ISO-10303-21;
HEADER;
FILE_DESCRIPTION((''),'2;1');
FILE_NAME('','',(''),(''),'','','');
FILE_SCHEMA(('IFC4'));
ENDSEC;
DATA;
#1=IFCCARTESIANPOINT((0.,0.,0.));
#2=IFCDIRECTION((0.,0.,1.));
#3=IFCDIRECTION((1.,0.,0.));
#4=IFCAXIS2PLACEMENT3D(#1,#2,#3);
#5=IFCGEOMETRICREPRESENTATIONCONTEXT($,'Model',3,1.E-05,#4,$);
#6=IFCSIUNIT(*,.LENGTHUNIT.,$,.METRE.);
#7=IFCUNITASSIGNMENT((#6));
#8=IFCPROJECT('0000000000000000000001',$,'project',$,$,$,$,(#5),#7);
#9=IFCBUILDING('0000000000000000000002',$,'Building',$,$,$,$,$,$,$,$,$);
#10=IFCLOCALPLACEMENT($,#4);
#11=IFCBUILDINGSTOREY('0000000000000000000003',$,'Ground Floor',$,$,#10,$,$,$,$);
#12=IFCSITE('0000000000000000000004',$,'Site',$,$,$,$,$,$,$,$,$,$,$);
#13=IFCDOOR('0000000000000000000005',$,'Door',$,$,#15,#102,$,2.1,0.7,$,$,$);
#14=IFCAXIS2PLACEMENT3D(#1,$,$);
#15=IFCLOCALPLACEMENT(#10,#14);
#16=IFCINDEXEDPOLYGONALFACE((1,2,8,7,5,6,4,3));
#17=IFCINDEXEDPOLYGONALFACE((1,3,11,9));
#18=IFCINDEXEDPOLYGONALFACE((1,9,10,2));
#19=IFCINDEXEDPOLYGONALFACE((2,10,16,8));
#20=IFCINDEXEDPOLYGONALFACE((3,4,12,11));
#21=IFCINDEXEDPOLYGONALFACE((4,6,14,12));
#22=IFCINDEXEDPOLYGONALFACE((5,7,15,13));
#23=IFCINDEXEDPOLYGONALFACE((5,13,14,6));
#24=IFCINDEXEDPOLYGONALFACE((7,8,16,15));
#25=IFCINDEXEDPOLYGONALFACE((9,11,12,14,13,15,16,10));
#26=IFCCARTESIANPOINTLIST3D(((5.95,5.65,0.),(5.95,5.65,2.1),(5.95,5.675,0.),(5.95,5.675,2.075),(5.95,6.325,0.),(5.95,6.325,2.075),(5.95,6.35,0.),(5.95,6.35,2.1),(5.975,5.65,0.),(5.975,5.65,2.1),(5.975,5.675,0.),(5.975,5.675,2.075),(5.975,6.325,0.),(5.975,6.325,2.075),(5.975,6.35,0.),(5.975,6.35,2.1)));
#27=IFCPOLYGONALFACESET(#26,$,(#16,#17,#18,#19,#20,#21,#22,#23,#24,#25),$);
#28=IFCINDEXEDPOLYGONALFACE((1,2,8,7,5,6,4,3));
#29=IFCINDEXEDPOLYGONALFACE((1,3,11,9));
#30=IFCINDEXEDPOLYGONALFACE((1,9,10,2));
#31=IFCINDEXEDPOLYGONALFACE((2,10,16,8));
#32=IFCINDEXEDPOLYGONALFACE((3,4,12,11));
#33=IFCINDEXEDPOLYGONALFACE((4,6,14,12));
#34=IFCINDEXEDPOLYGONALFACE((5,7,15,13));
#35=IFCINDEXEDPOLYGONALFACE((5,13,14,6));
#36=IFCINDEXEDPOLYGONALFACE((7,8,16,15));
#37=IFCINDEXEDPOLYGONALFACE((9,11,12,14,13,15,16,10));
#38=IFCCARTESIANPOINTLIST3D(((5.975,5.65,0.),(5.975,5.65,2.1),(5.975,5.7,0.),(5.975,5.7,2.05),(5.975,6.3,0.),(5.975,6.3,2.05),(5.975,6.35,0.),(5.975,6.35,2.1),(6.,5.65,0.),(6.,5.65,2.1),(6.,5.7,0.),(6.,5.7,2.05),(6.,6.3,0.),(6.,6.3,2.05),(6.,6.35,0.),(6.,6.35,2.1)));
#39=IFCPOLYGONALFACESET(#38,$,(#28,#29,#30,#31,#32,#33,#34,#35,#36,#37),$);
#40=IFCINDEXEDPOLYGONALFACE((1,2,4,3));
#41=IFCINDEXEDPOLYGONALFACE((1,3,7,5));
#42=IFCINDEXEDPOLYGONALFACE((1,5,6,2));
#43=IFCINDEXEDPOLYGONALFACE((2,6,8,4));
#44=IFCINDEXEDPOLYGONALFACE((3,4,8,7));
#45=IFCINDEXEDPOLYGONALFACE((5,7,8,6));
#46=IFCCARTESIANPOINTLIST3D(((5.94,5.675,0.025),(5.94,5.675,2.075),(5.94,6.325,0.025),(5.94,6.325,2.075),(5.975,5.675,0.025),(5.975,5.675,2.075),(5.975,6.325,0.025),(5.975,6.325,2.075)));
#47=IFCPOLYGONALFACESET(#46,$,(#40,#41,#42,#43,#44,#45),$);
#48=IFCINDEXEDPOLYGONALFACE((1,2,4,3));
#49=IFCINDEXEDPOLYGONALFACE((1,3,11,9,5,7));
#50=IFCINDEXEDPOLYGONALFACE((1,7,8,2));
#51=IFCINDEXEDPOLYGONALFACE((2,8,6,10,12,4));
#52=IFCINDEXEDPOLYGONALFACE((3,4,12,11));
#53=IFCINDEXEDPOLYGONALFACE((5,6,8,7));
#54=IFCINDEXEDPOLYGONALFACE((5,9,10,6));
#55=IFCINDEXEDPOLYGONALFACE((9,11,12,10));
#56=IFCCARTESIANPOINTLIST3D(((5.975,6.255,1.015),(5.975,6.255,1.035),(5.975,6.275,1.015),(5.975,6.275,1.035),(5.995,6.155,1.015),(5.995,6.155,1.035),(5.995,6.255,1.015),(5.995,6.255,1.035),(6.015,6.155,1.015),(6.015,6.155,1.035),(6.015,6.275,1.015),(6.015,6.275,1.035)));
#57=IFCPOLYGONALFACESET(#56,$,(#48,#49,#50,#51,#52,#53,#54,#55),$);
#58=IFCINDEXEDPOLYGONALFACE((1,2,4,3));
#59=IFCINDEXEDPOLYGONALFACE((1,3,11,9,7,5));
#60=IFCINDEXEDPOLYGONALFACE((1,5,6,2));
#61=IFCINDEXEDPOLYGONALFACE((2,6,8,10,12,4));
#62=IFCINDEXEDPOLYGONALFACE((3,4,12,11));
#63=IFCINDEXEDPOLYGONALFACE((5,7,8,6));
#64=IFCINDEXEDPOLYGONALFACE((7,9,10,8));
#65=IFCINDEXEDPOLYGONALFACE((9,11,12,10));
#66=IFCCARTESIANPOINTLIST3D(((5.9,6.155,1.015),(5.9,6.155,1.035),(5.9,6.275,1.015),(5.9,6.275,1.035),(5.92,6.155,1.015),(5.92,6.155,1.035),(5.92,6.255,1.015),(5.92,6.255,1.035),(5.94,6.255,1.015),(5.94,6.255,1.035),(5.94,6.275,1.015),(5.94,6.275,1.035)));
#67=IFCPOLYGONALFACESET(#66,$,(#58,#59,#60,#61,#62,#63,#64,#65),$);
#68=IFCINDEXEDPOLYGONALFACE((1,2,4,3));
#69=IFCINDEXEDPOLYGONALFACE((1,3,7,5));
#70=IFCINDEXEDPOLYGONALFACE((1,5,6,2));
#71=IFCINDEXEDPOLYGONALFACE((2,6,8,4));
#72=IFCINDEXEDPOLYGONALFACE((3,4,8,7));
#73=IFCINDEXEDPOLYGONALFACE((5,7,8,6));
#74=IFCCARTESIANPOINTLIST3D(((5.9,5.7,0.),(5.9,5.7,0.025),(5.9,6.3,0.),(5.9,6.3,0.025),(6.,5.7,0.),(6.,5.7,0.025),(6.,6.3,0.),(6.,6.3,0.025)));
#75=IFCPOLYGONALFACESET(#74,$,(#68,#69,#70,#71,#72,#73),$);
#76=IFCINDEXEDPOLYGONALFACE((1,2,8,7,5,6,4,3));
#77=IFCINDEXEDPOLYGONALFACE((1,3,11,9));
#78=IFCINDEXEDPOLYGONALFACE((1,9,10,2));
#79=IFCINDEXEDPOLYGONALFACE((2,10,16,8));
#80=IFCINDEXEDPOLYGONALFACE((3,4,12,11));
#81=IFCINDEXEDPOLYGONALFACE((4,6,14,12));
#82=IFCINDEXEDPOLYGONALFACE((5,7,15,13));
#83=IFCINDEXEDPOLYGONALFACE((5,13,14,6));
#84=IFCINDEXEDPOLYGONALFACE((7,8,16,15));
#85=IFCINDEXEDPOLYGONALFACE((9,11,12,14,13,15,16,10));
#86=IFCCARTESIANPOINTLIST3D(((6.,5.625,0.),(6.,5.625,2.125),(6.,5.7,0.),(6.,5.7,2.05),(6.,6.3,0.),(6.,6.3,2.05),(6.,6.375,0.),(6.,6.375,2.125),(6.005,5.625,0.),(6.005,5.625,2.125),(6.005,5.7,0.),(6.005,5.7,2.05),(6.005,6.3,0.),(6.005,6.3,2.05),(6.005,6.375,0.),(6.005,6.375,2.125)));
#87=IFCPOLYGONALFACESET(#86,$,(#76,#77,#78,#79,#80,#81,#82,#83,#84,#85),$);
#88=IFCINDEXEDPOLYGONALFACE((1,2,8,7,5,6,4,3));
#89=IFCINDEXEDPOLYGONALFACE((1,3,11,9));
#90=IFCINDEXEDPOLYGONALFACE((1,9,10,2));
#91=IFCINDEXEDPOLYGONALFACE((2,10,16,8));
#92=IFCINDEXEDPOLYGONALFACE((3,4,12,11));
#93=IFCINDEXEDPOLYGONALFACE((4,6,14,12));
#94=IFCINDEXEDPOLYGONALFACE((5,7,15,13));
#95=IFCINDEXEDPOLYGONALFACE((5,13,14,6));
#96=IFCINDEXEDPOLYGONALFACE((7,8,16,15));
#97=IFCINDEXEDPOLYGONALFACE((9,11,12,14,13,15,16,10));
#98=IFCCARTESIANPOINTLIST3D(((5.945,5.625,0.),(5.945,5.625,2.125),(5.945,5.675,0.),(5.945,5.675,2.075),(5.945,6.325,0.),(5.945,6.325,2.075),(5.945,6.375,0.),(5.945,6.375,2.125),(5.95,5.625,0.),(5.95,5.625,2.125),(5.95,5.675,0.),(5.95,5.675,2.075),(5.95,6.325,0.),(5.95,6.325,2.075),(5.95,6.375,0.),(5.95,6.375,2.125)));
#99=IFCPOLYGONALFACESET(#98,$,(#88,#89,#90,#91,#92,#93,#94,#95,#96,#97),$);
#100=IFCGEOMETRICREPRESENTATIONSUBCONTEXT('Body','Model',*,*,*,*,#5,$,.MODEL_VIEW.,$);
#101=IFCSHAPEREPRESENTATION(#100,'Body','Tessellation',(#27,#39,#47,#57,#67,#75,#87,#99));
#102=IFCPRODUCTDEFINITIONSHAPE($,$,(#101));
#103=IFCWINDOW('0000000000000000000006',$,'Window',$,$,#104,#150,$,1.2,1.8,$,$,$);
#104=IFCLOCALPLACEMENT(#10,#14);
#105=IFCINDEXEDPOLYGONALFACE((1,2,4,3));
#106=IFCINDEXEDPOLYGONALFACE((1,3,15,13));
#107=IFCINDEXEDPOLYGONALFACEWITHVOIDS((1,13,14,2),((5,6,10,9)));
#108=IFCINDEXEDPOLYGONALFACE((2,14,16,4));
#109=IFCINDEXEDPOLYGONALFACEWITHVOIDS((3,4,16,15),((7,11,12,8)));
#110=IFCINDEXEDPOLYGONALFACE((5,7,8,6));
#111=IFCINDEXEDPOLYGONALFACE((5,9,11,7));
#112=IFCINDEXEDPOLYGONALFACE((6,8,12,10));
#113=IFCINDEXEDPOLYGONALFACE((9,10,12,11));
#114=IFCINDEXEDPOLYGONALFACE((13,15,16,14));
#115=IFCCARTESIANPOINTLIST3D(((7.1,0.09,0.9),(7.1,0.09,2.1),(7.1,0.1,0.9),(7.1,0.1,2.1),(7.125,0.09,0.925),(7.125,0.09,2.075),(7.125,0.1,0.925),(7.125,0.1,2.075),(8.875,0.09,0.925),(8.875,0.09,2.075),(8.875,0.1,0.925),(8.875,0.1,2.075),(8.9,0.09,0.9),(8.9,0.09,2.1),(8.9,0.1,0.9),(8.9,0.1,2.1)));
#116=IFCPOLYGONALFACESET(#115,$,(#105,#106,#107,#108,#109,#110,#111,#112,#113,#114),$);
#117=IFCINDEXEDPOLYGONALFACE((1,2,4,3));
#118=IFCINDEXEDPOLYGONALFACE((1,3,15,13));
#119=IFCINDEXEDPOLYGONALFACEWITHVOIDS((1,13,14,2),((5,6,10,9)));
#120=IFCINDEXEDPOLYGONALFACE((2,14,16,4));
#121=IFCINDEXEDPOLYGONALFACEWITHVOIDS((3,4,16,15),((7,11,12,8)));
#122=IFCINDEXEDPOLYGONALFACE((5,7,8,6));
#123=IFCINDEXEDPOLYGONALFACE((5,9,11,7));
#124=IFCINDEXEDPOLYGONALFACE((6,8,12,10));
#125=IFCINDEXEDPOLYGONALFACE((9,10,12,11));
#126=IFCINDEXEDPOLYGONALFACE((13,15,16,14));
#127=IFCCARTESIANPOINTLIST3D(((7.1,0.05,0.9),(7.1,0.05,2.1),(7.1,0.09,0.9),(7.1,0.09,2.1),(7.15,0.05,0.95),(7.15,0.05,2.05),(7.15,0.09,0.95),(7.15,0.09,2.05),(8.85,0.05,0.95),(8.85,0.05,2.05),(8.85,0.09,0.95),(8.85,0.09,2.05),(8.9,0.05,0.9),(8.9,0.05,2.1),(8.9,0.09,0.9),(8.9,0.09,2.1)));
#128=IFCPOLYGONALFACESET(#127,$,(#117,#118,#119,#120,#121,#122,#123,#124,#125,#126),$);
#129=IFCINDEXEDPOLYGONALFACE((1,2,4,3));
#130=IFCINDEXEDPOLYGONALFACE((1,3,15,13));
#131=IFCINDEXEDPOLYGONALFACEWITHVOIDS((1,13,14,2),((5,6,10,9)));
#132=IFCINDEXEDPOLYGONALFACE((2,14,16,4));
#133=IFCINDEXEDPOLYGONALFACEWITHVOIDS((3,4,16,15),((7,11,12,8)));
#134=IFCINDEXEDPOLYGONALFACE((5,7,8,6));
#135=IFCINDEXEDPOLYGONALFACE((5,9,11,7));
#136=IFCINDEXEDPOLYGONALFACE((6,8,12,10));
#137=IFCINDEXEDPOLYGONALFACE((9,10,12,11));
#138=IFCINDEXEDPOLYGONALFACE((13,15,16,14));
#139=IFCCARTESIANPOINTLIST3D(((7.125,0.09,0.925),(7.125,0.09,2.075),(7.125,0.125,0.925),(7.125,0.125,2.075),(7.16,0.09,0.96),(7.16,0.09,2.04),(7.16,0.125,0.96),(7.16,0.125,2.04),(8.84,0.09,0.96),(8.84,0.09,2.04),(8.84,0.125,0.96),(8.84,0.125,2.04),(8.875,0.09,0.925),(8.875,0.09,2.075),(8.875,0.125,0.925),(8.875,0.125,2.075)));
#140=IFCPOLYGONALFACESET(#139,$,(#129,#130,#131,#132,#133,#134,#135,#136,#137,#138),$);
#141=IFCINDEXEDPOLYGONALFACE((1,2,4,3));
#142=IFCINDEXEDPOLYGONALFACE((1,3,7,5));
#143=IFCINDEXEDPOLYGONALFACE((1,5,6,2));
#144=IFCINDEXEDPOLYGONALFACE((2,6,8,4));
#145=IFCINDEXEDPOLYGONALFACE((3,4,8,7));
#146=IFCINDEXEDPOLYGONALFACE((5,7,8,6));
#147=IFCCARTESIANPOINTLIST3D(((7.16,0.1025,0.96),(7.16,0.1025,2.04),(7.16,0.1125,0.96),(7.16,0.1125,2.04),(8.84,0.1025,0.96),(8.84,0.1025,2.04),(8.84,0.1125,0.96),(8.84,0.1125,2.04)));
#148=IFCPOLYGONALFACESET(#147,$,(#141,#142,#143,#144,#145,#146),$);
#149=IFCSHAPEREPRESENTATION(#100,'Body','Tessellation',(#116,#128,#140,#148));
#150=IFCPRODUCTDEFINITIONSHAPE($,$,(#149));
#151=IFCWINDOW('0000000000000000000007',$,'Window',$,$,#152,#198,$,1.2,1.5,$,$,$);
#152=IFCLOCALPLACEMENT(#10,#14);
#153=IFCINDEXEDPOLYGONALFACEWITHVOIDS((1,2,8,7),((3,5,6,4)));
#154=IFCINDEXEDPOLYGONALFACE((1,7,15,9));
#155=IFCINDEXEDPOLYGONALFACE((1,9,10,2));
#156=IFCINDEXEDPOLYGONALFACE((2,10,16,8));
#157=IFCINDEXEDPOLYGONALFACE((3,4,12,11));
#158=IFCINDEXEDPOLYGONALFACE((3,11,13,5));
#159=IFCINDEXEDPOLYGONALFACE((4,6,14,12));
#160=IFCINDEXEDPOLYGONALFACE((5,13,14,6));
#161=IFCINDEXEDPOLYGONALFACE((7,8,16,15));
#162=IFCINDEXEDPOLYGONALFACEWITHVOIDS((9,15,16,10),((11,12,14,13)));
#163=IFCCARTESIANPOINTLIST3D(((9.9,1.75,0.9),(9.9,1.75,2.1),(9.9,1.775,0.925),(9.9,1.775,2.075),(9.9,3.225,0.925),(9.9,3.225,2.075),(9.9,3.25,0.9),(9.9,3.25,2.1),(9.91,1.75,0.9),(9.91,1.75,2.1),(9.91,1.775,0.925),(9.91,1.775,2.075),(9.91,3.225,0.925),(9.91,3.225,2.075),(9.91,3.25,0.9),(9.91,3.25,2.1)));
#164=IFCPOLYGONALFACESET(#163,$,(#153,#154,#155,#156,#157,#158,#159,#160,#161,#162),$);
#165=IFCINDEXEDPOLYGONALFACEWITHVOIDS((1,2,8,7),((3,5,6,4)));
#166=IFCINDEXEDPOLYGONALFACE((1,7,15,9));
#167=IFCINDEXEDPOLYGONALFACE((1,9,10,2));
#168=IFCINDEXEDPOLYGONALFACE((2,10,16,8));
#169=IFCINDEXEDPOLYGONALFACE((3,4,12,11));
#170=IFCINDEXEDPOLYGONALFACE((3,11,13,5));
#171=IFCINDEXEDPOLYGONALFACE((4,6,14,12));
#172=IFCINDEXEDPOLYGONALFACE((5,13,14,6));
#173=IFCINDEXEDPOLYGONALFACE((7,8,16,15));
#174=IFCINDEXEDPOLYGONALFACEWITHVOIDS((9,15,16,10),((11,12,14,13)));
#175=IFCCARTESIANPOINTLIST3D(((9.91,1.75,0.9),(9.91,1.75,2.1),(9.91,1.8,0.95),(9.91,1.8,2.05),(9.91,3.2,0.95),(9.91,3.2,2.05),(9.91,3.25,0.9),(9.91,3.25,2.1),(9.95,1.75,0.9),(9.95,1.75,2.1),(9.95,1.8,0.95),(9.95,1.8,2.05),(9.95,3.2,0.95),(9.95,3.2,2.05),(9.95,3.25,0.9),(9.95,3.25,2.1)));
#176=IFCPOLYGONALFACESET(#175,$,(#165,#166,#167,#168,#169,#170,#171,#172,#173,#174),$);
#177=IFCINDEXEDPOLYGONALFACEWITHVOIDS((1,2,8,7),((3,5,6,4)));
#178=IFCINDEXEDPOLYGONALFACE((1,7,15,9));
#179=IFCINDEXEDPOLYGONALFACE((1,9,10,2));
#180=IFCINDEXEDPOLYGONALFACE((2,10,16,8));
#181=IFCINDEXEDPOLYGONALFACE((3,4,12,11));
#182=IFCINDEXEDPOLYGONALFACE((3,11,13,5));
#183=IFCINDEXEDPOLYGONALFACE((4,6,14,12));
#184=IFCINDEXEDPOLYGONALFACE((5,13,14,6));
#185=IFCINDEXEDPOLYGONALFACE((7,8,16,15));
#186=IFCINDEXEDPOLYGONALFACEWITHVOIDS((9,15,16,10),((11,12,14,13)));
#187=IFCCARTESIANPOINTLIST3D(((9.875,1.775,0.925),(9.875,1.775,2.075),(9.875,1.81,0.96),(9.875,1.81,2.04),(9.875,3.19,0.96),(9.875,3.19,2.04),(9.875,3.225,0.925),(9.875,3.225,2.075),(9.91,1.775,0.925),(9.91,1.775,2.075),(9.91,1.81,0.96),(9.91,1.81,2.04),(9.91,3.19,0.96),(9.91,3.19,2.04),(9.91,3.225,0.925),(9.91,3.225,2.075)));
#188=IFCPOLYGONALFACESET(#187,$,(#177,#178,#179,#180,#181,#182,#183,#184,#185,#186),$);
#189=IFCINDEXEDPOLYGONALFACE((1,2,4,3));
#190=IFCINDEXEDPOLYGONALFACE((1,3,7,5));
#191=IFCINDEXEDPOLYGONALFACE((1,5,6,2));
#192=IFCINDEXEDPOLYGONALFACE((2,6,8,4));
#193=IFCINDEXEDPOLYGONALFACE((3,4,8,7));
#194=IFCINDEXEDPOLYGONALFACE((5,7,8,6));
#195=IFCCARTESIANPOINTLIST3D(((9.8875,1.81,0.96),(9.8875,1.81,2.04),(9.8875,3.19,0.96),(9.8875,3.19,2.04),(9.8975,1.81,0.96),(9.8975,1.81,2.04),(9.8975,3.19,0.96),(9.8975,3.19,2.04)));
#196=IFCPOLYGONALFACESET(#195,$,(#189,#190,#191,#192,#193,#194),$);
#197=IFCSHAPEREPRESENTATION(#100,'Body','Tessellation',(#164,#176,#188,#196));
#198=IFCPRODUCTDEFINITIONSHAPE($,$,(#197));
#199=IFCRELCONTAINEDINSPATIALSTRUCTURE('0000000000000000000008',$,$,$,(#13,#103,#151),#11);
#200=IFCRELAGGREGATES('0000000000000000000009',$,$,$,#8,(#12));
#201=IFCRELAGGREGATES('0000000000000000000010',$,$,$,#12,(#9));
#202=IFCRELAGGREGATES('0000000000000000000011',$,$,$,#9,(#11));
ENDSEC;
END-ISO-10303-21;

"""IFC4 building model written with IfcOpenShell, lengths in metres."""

from ifc_helpers import new_model, si_unit, frame, origin_with_axes, place, context, subcontext, project, spatial, line, indexed_curve, outline, extrude, element, save


model = new_model("IFC4")

# Units and contexts
model_context = context("Model", 3, precision=1e-05, world=origin_with_axes())
body_context = subcontext(model_context, "Body", "Model", "MODEL_VIEW")
ifc_project = project(units=[si_unit("LENGTHUNIT", "METRE")], contexts=[model_context])

# Site, building, storey
site = spatial("IfcSite", under=ifc_project, Name="Site")
building = spatial("IfcBuilding", under=site, Name="Building")
storey_placement = place(None, origin_with_axes())
storey = spatial("IfcBuildingStorey", under=building, at=storey_placement, Name="Ground Floor")

# Door
door_1_placement = place(storey_placement, frame((6.0, 5.65, 0.0), z_axis=(0.0, 0.0, 1.0), x_axis=(0.0, 1.0, 0.0)))
element("IfcDoor", 1, at=door_1_placement, inside=storey, Name="Door", OverallHeight=2.1, OverallWidth=0.7, context=body_context, shape_type="SweptSolid", body=[
    extrude(outline(indexed_curve([(0.0, 0.0), (0.0, 2.1), (0.7, 2.1), (0.7, 0.0), (0.675, 0.0), (0.675, 2.075), (0.025, 2.075), (0.025, 0.0)], segments=[line(1, 2, 3, 4, 5, 6, 7, 8, 1)])), frame((0.0, 0.025, 0.0), z_axis=(0.0, -1.0, 0.0), x_axis=(1.0, 0.0, 0.0)), (0.0, 0.0, -1.0), 0.025),
    extrude(outline(indexed_curve([(0.0, 0.0), (0.0, 2.1), (0.7, 2.1), (0.7, 0.0), (0.65, 0.0), (0.65, 2.05), (0.05, 2.05), (0.05, 0.0)], segments=[line(1, 2, 3, 4, 5, 6, 7, 8, 1)])), frame((0.0, 0.0, 0.0), z_axis=(0.0, -1.0, 0.0), x_axis=(1.0, 0.0, 0.0)), (0.0, 0.0, -1.0), 0.025),
    extrude(outline(indexed_curve([(0.0, 0.0), (0.65, 0.0), (0.65, 0.035), (0.0, 0.035)], segments=[line(1, 2, 3, 4, 1)])), frame((0.025, 0.025, 0.025), z_axis=(0.0, 0.0, 1.0), x_axis=(1.0, 0.0, 0.0)), (0.0, 0.0, 1.0), 2.05),
    extrude(outline(indexed_curve([(0.0, 0.0), (0.0, -0.04), (-0.12, -0.04), (-0.12, -0.02), (-0.02, -0.02), (-0.02, 0.0)], segments=[line(1, 2, 3, 4, 5, 6, 1)])), frame((0.625, 0.025, 1.015), z_axis=(0.0, 0.0, 1.0), x_axis=(1.0, 0.0, 0.0)), (0.0, 0.0, 1.0), 0.02),
    extrude(outline(indexed_curve([(0.0, 0.0), (0.0, 0.04), (-0.12, 0.04), (-0.12, 0.02), (-0.02, 0.02), (-0.02, 0.0)], segments=[line(1, 2, 3, 4, 5, 6, 1)])), frame((0.625, 0.06, 1.015), z_axis=(0.0, 0.0, 1.0), x_axis=(1.0, 0.0, 0.0)), (0.0, 0.0, 1.0), 0.02),
    extrude(outline(indexed_curve([(0.0, 0.0), (0.6, 0.0), (0.6, 0.1), (0.0, 0.1)], segments=[line(1, 2, 3, 4, 1)])), frame((0.05, 0.0, 0.0), z_axis=(0.0, 0.0, 1.0), x_axis=(1.0, 0.0, 0.0)), (0.0, 0.0, 1.0), 0.025),
    extrude(outline(indexed_curve([(0.0, 0.0), (0.0, 2.125), (0.75, 2.125), (0.75, 0.0), (0.675, 0.0), (0.675, 2.05), (0.075, 2.05), (0.075, 0.0)], segments=[line(1, 2, 3, 4, 5, 6, 7, 8, 1)])), frame((-0.025, -0.005, 0.0), z_axis=(0.0, -1.0, 0.0), x_axis=(1.0, 0.0, 0.0)), (0.0, 0.0, -1.0), 0.005),
    extrude(outline(indexed_curve([(0.0, 0.0), (0.0, 2.125), (0.75, 2.125), (0.75, 0.0), (0.7, 0.0), (0.7, 2.075), (0.05, 2.075), (0.05, 0.0)], segments=[line(1, 2, 3, 4, 5, 6, 7, 8, 1)])), frame((-0.025, 0.05, 0.0), z_axis=(0.0, -1.0, 0.0), x_axis=(1.0, 0.0, 0.0)), (0.0, 0.0, -1.0), 0.005),
])

# Windows
window_1_placement = place(storey_placement, frame((7.1, 0.0, 0.9), z_axis=(0.0, 0.0, 1.0), x_axis=(1.0, 0.0, 0.0)))
element("IfcWindow", 2, at=window_1_placement, inside=storey, Name="Window", OverallHeight=1.2, OverallWidth=1.8, context=body_context, shape_type="SweptSolid", body=[
    extrude(outline(indexed_curve([(0.0, 0.0), (1.8, 0.0), (1.8, 1.2), (0.0, 1.2)], segments=[line(1, 2, 3, 4, 1)]), holes=[indexed_curve([(0.025, 0.025), (1.775, 0.025), (1.775, 1.175), (0.025, 1.175)], segments=[line(1, 2, 3, 4, 1)])]), frame((0.0, 0.09, 0.0), z_axis=(0.0, -1.0, 0.0), x_axis=(1.0, 0.0, 0.0)), (0.0, 0.0, -1.0), 0.01),
    extrude(outline(indexed_curve([(0.0, 0.0), (1.8, 0.0), (1.8, 1.2), (0.0, 1.2)], segments=[line(1, 2, 3, 4, 1)]), holes=[indexed_curve([(0.05, 0.05), (1.75, 0.05), (1.75, 1.15), (0.05, 1.15)], segments=[line(1, 2, 3, 4, 1)])]), frame((0.0, 0.05, 0.0), z_axis=(0.0, -1.0, 0.0), x_axis=(1.0, 0.0, 0.0)), (0.0, 0.0, -1.0), 0.04),
    extrude(outline(indexed_curve([(0.0, 0.0), (1.75, 0.0), (1.75, 1.15), (0.0, 1.15)], segments=[line(1, 2, 3, 4, 1)]), holes=[indexed_curve([(0.035, 0.035), (1.715, 0.035), (1.715, 1.115), (0.035, 1.115)], segments=[line(1, 2, 3, 4, 1)])]), frame((0.025, 0.09, 0.025), z_axis=(0.0, -1.0, 0.0), x_axis=(1.0, 0.0, 0.0)), (0.0, 0.0, -1.0), 0.035),
    extrude(outline(indexed_curve([(0.035, 0.035), (1.715, 0.035), (1.715, 1.115), (0.035, 1.115)], segments=[line(1, 2, 3, 4, 1)])), frame((0.025, 0.1025, 0.025), z_axis=(0.0, -1.0, 0.0), x_axis=(1.0, 0.0, 0.0)), (0.0, 0.0, -1.0), 0.01),
])
window_2_placement = place(storey_placement, frame((10.0, 1.75, 0.9), z_axis=(0.0, 0.0, 1.0), x_axis=(0.0, 1.0, 0.0)))
element("IfcWindow", 3, at=window_2_placement, inside=storey, Name="Window", OverallHeight=1.2, OverallWidth=1.5, context=body_context, shape_type="SweptSolid", body=[
    extrude(outline(indexed_curve([(0.0, 0.0), (1.5, 0.0), (1.5, 1.2), (0.0, 1.2)], segments=[line(1, 2, 3, 4, 1)]), holes=[indexed_curve([(0.025, 0.025), (1.475, 0.025), (1.475, 1.175), (0.025, 1.175)], segments=[line(1, 2, 3, 4, 1)])]), frame((0.0, 0.09, 0.0), z_axis=(0.0, -1.0, 0.0), x_axis=(1.0, 0.0, 0.0)), (0.0, 0.0, -1.0), 0.01),
    extrude(outline(indexed_curve([(0.0, 0.0), (1.5, 0.0), (1.5, 1.2), (0.0, 1.2)], segments=[line(1, 2, 3, 4, 1)]), holes=[indexed_curve([(0.05, 0.05), (1.45, 0.05), (1.45, 1.15), (0.05, 1.15)], segments=[line(1, 2, 3, 4, 1)])]), frame((0.0, 0.05, 0.0), z_axis=(0.0, -1.0, 0.0), x_axis=(1.0, 0.0, 0.0)), (0.0, 0.0, -1.0), 0.04),
    extrude(outline(indexed_curve([(0.0, 0.0), (1.45, 0.0), (1.45, 1.15), (0.0, 1.15)], segments=[line(1, 2, 3, 4, 1)]), holes=[indexed_curve([(0.035, 0.035), (1.415, 0.035), (1.415, 1.115), (0.035, 1.115)], segments=[line(1, 2, 3, 4, 1)])]), frame((0.025, 0.09, 0.025), z_axis=(0.0, -1.0, 0.0), x_axis=(1.0, 0.0, 0.0)), (0.0, 0.0, -1.0), 0.035),
    extrude(outline(indexed_curve([(0.035, 0.035), (1.415, 0.035), (1.415, 1.115), (0.035, 1.115)], segments=[line(1, 2, 3, 4, 1)])), frame((0.025, 0.1025, 0.025), z_axis=(0.0, -1.0, 0.0), x_axis=(1.0, 0.0, 0.0)), (0.0, 0.0, -1.0), 0.01),
])

save(model, "model.ifc")
